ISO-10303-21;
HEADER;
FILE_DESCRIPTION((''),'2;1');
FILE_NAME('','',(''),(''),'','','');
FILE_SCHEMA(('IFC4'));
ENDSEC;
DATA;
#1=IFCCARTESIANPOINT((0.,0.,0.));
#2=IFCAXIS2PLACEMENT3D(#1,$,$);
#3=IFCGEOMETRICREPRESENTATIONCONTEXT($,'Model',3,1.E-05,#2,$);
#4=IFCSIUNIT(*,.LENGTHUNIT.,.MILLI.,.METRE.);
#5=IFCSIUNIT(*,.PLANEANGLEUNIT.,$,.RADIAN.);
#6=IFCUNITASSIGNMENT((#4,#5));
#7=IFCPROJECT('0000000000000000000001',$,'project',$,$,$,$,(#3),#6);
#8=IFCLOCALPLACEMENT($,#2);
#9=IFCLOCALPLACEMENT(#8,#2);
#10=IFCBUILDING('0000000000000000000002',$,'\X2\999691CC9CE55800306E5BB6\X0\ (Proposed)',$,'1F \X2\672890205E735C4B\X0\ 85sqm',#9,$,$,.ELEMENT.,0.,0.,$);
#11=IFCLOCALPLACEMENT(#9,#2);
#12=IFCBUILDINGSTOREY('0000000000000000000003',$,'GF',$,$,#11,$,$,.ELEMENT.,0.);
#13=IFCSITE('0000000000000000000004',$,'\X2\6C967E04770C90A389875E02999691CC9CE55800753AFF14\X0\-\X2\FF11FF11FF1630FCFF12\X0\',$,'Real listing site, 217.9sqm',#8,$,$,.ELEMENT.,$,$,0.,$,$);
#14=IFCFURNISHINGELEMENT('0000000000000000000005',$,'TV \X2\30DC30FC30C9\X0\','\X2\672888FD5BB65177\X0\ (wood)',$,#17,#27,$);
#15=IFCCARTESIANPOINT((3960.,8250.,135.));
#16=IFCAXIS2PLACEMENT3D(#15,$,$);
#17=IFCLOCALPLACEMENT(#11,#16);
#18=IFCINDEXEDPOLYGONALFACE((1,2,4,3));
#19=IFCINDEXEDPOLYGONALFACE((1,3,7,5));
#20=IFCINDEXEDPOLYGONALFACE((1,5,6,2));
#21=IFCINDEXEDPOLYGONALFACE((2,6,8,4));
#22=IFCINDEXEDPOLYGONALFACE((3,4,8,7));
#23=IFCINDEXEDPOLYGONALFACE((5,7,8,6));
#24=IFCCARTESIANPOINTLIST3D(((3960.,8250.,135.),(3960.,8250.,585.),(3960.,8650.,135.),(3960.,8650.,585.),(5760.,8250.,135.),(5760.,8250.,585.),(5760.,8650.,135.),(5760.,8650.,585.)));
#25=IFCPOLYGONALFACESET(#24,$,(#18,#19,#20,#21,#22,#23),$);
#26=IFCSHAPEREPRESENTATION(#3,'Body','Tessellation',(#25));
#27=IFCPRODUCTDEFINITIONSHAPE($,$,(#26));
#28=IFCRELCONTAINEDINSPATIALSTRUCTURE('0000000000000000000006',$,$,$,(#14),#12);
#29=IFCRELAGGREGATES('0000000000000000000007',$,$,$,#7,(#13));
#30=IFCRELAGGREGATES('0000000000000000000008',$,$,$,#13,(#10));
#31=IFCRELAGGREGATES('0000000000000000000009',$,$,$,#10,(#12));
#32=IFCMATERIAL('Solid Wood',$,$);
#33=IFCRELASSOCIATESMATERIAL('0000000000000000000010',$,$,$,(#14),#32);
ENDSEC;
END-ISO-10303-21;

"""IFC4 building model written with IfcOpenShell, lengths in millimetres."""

from ifc_helpers import new_model, si_unit, frame, frame_2d, origin, place, context, project, spatial, rectangle, extrude, material, element, save


model = new_model("IFC4")

# Units and contexts
model_context = context("Model", 3, precision=1e-05, world=origin())
ifc_project = project(units=[si_unit("LENGTHUNIT", "METRE", prefix="MILLI"), si_unit("PLANEANGLEUNIT", "RADIAN")], contexts=[model_context])

# Site, building, storey
site_placement = place(None, origin())
site = spatial("IfcSite", under=ifc_project, at=site_placement, Name="沖縄県那覇市首里鳥堀町４-１１６ー２", ObjectType="Real listing site, 217.9sqm", CompositionType="ELEMENT", RefElevation=0.0)
building_placement = place(site_placement, origin())
building = spatial("IfcBuilding", under=site, at=building_placement, Name="首里鳥堀の家 (Proposed)", ObjectType="1F 木造平屋 85sqm", CompositionType="ELEMENT", ElevationOfRefHeight=0.0, ElevationOfTerrain=0.0)
storey_placement = place(building_placement, origin())
storey = spatial("IfcBuildingStorey", under=building, at=storey_placement, Name="GF", CompositionType="ELEMENT", Elevation=0.0)

# Shared definitions
ifc_material_1 = material(Name="Solid Wood")

# Furnishing element
furnishing_placement = place(storey_placement, frame((3960.0, 8250.0, 135.0)))
element("IfcFurnishingElement", 1, at=furnishing_placement, inside=storey, material=ifc_material_1, Name="TV ボード", Description="木製家具 (wood)", context=model_context, shape_type="SweptSolid", body=[
    extrude(rectangle(XDim=1800.0, YDim=400.0, at=frame_2d((900.0, 200.0))), frame((3960.0, 8250.0, 135.0)), (0.0, 0.0, 1.0), 450.0),
])

save(model, "model.ifc")
